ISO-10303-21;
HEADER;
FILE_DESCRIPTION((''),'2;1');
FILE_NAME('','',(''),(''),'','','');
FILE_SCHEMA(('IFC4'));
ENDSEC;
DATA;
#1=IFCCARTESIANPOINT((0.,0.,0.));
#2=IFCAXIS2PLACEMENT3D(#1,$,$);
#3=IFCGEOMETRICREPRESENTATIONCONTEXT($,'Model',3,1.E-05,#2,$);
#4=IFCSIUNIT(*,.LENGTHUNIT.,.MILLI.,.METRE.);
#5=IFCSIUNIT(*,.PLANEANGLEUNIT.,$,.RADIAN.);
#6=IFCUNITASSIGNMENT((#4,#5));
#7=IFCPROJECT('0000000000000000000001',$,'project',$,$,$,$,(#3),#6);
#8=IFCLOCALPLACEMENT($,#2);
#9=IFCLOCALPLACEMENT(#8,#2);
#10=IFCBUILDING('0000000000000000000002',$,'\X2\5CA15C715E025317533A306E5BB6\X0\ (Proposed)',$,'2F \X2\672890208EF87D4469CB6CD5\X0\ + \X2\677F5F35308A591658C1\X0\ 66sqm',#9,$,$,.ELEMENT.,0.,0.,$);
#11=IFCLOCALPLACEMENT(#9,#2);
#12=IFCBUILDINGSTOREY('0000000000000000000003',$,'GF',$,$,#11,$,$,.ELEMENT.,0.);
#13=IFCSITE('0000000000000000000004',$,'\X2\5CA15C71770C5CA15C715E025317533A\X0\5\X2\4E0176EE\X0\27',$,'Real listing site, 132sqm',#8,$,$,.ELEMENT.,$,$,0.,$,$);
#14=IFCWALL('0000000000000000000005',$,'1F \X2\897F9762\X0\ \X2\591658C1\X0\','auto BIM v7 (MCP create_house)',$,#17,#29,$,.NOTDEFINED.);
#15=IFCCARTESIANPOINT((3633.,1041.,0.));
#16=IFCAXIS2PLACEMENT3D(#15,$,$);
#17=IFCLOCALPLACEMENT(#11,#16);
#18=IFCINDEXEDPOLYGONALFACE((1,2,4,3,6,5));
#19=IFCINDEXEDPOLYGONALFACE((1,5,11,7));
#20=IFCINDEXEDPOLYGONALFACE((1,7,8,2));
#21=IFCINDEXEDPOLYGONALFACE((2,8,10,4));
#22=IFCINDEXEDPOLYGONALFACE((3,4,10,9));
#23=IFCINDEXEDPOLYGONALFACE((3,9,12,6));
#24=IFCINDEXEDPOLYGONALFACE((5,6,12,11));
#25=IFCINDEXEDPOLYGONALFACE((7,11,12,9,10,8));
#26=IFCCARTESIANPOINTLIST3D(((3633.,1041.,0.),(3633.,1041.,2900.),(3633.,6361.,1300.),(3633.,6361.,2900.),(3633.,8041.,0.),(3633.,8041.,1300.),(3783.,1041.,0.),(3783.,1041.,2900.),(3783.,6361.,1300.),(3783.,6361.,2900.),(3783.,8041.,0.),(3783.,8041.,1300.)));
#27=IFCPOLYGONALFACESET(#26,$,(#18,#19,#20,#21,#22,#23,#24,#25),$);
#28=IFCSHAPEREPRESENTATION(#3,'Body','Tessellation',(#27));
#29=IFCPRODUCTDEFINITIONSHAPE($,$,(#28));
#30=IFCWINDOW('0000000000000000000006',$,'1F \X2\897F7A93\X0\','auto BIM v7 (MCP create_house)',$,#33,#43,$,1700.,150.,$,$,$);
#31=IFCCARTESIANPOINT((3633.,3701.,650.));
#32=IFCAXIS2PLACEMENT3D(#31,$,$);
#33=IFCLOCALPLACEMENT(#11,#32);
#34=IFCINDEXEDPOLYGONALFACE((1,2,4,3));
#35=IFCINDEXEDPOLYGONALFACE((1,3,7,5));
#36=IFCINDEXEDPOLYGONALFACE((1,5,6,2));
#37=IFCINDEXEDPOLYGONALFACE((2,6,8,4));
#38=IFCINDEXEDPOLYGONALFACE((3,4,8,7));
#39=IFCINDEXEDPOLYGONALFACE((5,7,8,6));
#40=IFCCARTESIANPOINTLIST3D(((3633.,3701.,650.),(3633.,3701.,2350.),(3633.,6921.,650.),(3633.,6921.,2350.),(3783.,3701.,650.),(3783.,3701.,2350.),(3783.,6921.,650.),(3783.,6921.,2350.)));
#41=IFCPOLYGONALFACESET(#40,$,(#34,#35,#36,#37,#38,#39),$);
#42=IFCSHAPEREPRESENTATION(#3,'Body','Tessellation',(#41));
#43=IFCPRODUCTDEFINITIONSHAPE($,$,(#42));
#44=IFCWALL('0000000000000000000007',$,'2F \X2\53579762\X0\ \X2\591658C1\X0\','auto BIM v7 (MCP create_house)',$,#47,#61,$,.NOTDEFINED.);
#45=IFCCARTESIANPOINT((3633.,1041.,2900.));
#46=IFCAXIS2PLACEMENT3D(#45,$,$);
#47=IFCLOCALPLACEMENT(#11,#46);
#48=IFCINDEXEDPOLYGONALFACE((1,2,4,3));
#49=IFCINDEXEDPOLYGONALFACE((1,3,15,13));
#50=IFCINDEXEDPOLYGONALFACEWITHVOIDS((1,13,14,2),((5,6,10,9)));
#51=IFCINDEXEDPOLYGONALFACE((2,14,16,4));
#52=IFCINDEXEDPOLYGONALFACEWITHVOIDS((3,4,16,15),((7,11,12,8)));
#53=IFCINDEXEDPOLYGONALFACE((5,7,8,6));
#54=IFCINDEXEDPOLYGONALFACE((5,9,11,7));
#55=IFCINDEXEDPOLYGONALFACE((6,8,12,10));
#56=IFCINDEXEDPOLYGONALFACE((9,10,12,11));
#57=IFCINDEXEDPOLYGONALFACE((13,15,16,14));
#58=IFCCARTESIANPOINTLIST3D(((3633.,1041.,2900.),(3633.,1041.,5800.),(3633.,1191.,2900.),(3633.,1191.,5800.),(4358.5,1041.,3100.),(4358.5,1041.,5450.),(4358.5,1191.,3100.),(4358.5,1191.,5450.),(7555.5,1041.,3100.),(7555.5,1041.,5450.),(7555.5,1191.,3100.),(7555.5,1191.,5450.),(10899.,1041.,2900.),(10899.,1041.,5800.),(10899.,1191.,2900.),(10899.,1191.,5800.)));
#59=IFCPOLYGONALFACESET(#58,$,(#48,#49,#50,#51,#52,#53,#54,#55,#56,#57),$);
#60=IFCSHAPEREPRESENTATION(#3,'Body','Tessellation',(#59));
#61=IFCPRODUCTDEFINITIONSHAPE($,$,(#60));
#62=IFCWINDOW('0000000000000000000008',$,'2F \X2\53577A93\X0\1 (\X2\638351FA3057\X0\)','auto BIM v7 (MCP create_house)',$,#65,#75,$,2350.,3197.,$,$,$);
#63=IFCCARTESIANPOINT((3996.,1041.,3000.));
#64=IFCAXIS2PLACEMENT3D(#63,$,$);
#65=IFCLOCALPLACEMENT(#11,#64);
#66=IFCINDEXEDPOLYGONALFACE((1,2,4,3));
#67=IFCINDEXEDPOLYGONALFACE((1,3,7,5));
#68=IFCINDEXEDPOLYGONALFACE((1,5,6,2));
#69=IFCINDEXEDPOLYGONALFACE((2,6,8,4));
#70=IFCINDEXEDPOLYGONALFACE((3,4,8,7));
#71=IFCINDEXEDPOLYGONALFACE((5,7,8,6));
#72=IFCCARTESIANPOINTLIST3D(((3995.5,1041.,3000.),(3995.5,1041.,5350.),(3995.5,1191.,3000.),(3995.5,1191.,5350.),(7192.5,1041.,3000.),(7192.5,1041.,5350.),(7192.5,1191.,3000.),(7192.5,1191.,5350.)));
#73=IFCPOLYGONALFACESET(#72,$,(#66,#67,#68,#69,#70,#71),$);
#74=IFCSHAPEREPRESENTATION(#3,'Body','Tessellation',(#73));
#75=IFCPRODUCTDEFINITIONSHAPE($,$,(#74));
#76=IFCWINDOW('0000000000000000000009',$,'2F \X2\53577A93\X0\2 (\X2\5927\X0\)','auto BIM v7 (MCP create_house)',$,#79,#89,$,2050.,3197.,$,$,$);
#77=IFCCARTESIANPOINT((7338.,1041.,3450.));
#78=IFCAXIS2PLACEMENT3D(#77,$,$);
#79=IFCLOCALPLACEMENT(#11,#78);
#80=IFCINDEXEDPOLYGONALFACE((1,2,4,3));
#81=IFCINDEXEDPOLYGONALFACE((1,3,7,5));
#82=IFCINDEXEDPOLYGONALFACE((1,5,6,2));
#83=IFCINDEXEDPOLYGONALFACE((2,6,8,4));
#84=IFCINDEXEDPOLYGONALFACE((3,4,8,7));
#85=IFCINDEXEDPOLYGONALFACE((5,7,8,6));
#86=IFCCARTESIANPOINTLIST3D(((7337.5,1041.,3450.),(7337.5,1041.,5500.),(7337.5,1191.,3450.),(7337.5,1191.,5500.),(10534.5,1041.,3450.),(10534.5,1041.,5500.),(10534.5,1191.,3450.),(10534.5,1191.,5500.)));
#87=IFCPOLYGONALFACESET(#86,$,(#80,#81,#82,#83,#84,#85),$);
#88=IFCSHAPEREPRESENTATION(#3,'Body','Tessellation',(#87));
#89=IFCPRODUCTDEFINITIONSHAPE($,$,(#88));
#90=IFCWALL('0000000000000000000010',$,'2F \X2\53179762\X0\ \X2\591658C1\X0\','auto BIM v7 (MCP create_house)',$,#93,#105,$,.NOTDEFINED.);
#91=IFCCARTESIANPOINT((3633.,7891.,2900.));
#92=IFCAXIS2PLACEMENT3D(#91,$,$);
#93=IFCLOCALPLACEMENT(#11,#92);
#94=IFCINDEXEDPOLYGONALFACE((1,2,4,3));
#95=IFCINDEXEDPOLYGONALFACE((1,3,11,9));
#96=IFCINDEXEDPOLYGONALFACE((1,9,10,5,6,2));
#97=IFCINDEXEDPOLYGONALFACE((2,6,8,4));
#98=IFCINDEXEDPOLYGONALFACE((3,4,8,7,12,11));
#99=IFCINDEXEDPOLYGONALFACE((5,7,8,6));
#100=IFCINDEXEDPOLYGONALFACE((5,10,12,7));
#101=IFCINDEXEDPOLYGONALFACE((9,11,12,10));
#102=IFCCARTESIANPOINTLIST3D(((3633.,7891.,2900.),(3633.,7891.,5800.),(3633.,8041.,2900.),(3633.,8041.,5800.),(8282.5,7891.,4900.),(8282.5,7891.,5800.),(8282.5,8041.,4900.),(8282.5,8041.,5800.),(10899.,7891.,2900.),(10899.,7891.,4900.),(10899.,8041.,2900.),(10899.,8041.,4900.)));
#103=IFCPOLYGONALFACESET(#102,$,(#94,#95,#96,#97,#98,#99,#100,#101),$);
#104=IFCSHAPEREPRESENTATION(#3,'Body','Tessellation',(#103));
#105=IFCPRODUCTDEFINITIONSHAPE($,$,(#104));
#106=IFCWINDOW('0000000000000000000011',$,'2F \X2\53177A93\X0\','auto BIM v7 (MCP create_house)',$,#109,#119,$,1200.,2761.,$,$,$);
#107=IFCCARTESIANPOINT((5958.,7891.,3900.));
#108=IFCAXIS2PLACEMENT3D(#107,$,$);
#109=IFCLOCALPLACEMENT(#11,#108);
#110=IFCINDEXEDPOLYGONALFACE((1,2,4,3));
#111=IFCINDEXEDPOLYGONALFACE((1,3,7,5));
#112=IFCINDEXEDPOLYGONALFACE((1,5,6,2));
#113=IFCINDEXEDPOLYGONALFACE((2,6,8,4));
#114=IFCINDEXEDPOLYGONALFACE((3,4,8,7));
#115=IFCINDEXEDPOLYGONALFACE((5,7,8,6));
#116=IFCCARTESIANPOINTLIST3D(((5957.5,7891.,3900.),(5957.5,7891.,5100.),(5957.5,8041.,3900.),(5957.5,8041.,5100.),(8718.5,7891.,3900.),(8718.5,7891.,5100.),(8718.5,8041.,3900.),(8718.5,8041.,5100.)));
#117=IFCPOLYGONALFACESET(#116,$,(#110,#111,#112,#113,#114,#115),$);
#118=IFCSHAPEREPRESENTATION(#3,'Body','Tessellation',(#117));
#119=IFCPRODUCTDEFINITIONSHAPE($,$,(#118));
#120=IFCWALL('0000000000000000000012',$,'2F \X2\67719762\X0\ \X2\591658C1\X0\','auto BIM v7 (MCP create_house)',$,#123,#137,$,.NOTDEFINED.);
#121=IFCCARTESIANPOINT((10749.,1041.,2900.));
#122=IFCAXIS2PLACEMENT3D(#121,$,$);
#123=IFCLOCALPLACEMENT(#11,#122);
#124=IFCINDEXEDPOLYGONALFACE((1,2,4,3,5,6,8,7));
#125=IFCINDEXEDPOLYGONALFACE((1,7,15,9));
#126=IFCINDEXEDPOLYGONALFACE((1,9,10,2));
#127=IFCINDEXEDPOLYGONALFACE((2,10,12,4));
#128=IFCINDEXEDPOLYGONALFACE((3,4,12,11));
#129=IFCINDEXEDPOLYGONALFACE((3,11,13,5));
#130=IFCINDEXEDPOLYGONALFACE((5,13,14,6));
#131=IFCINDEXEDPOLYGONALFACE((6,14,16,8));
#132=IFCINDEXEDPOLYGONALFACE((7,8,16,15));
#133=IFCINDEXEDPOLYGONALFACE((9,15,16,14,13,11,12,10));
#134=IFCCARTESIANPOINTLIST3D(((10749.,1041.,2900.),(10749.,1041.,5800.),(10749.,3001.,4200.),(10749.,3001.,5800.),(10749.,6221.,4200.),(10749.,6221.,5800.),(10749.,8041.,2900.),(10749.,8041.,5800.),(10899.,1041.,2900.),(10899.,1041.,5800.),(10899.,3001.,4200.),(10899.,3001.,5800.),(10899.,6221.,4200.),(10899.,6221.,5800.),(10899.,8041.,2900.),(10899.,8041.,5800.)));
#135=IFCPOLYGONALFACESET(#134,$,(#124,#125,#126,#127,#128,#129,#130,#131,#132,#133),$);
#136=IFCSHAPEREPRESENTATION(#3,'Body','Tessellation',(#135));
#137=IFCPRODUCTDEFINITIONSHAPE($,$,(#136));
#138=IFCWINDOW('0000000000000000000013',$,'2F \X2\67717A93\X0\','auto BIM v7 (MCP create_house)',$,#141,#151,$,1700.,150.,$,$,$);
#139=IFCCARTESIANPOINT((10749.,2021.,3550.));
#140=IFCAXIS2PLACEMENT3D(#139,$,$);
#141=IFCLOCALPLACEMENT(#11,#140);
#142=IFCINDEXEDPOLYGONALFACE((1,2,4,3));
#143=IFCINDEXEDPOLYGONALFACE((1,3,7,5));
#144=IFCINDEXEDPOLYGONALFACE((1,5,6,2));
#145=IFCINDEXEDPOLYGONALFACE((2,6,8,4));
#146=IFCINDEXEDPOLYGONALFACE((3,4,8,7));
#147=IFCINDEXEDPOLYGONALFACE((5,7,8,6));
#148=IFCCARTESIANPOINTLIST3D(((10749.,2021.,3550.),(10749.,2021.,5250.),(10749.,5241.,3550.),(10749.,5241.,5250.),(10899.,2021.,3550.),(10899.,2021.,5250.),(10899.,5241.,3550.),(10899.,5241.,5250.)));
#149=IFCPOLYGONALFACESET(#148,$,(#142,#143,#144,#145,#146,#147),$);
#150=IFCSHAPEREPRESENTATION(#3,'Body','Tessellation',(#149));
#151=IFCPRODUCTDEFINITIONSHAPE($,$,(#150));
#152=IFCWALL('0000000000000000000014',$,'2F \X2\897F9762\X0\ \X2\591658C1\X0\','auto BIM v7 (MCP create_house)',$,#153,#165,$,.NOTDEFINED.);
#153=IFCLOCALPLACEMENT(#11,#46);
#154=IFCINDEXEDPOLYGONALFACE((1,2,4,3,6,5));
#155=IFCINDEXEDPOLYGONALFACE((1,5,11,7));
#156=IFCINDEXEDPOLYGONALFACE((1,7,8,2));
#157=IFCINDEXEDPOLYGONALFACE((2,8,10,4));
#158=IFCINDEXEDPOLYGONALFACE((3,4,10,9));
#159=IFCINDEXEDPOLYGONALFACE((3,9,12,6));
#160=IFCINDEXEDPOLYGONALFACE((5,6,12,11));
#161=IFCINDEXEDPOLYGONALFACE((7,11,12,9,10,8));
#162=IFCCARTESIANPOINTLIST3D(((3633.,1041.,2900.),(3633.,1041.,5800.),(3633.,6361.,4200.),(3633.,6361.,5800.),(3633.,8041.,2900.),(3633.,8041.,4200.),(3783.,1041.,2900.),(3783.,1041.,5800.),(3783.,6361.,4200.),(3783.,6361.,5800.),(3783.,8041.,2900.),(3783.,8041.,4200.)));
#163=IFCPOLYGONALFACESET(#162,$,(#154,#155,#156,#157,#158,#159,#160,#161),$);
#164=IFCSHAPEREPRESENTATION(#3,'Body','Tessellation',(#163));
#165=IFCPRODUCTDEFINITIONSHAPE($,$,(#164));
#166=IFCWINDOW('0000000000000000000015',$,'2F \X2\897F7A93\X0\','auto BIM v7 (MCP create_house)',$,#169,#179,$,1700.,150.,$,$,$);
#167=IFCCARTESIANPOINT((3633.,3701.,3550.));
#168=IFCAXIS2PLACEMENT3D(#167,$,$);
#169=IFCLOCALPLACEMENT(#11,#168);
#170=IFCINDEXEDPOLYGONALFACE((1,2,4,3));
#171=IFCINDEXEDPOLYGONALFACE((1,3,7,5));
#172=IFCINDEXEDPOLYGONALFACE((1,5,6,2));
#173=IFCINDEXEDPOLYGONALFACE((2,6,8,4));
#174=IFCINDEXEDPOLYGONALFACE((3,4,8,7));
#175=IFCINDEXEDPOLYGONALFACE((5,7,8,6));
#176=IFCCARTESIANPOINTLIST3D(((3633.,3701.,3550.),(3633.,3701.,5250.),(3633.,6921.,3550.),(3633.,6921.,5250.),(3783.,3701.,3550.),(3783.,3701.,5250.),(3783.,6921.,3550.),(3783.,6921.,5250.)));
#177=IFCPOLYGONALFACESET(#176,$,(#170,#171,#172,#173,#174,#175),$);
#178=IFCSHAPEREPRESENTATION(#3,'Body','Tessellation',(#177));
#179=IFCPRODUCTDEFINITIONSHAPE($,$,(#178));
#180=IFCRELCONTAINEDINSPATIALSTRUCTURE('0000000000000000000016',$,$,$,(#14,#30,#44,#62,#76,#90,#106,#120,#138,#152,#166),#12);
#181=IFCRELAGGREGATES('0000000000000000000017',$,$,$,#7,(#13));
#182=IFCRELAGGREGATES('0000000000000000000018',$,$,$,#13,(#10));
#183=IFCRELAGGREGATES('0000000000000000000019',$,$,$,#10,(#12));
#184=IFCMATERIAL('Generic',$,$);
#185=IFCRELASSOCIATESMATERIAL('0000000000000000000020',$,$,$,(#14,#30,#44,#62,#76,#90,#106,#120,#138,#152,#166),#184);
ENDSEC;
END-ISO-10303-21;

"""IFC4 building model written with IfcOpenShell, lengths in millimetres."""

from ifc_helpers import new_model, si_unit, frame, frame_2d, origin, place, context, project, spatial, rectangle, extrude, material, element, fill, save


model = new_model("IFC4")

# Units and contexts
model_context = context("Model", 3, precision=1e-05, world=origin())
ifc_project = project(units=[si_unit("LENGTHUNIT", "METRE", prefix="MILLI"), si_unit("PLANEANGLEUNIT", "RADIAN")], contexts=[model_context])

# Site, building, storey
site_placement = place(None, origin())
site = spatial("IfcSite", under=ifc_project, at=site_placement, Name="岡山県岡山市北区5丁目27", ObjectType="Real listing site, 132sqm", CompositionType="ELEMENT", RefElevation=0.0)
building_placement = place(site_placement, origin())
building = spatial("IfcBuilding", under=site, at=building_placement, Name="岡山市北区の家 (Proposed)", ObjectType="2F 木造軸組構法 + 板張り外壁 66sqm", CompositionType="ELEMENT", ElevationOfRefHeight=0.0, ElevationOfTerrain=0.0)
storey_placement = place(building_placement, origin())
storey = spatial("IfcBuildingStorey", under=building, at=storey_placement, Name="GF", CompositionType="ELEMENT", Elevation=0.0)

# Shared definitions
ifc_material = material(Name="Generic")

# Wall, opening, window
wall_1_placement = place(storey_placement, frame((3633.0, 1041.0, 0.0)))
wall_1 = element("IfcWall", 1, at=wall_1_placement, inside=storey, material=ifc_material, Name="1F 西面 外壁", Description="auto BIM v7 (MCP create_house)", PredefinedType="NOTDEFINED", context=model_context, shape_type="SweptSolid", body=[
    extrude(rectangle(XDim=150.0, YDim=7000.0, at=frame_2d((75.0, 3500.0))), frame((3633.0, 1041.0, 0.0)), (0.0, 0.0, 1.0), 2900.0),
])
opening_1_placement = place(storey_placement, frame((3633.0, 3701.0, 650.0)))
opening_1 = element("IfcOpeningElement", 2, at=opening_1_placement, cuts=wall_1, PredefinedType="NOTDEFINED", context=model_context, shape_type="SweptSolid", body=[
    extrude(rectangle(XDim=150.0, YDim=3220.0, at=frame_2d((75.0, 1610.0))), frame((3633.0, 3701.0, 650.0)), (0.0, 0.0, 1.0), 1700.0),
])
window_1_placement = place(storey_placement, frame((3633.0, 3701.0, 650.0)))
window_1 = element("IfcWindow", 3, at=window_1_placement, inside=storey, material=ifc_material, Name="1F 西窓", Description="auto BIM v7 (MCP create_house)", OverallHeight=1700.0, OverallWidth=150.0, context=model_context, shape_type="SweptSolid", body=[
    extrude(rectangle(XDim=150.0, YDim=3220.0, at=frame_2d((75.0, 1610.0))), frame((3633.0, 3701.0, 650.0)), (0.0, 0.0, 1.0), 1700.0),
])
fill(opening_1, window_1)

# Wall, openings, windows
wall_2_placement = place(storey_placement, frame((3633.0, 1041.0, 2900.0)))
wall_2 = element("IfcWall", 4, at=wall_2_placement, inside=storey, material=ifc_material, Name="2F 南面 外壁", Description="auto BIM v7 (MCP create_house)", PredefinedType="NOTDEFINED", context=model_context, shape_type="SweptSolid", body=[
    extrude(rectangle(XDim=7266.0, YDim=150.0, at=frame_2d((3633.0, 75.0))), frame((3633.0, 1041.0, 2900.0)), (0.0, 0.0, 1.0), 2900.0),
])
opening_2_placement = place(storey_placement, frame((3996.0, 1041.0, 3000.0)))
opening_2 = element("IfcOpeningElement", 5, at=opening_2_placement, cuts=wall_2, PredefinedType="NOTDEFINED", context=model_context, shape_type="SweptSolid", body=[
    extrude(rectangle(XDim=3197.0, YDim=150.0, at=frame_2d((1598.0, 75.0))), frame((3996.0, 1041.0, 3000.0)), (0.0, 0.0, 1.0), 2350.0),
])
opening_3_placement = place(storey_placement, frame((7338.0, 1041.0, 3450.0)))
opening_3 = element("IfcOpeningElement", 6, at=opening_3_placement, cuts=wall_2, PredefinedType="NOTDEFINED", context=model_context, shape_type="SweptSolid", body=[
    extrude(rectangle(XDim=3197.0, YDim=150.0, at=frame_2d((1598.0, 75.0))), frame((7338.0, 1041.0, 3450.0)), (0.0, 0.0, 1.0), 2050.0),
])
window_2_placement = place(storey_placement, frame((3996.0, 1041.0, 3000.0)))
window_2 = element("IfcWindow", 7, at=window_2_placement, inside=storey, material=ifc_material, Name="2F 南窓1 (掃出し)", Description="auto BIM v7 (MCP create_house)", OverallHeight=2350.0, OverallWidth=3197.0, context=model_context, shape_type="SweptSolid", body=[
    extrude(rectangle(XDim=3197.0, YDim=150.0, at=frame_2d((1598.0, 75.0))), frame((3996.0, 1041.0, 3000.0)), (0.0, 0.0, 1.0), 2350.0),
])
fill(opening_2, window_2)
window_3_placement = place(storey_placement, frame((7338.0, 1041.0, 3450.0)))
window_3 = element("IfcWindow", 8, at=window_3_placement, inside=storey, material=ifc_material, Name="2F 南窓2 (大)", Description="auto BIM v7 (MCP create_house)", OverallHeight=2050.0, OverallWidth=3197.0, context=model_context, shape_type="SweptSolid", body=[
    extrude(rectangle(XDim=3197.0, YDim=150.0, at=frame_2d((1598.0, 75.0))), frame((7338.0, 1041.0, 3450.0)), (0.0, 0.0, 1.0), 2050.0),
])
fill(opening_3, window_3)

# Walls, openings, windows
wall_3_placement = place(storey_placement, frame((3633.0, 7891.0, 2900.0)))
wall_3 = element("IfcWall", 9, at=wall_3_placement, inside=storey, material=ifc_material, Name="2F 北面 外壁", Description="auto BIM v7 (MCP create_house)", PredefinedType="NOTDEFINED", context=model_context, shape_type="SweptSolid", body=[
    extrude(rectangle(XDim=7266.0, YDim=150.0, at=frame_2d((3633.0, 75.0))), frame((3633.0, 7891.0, 2900.0)), (0.0, 0.0, 1.0), 2900.0),
])
opening_4_placement = place(storey_placement, frame((5958.0, 7891.0, 3900.0)))
opening_4 = element("IfcOpeningElement", 10, at=opening_4_placement, cuts=wall_3, PredefinedType="NOTDEFINED", context=model_context, shape_type="SweptSolid", body=[
    extrude(rectangle(XDim=2761.0, YDim=150.0, at=frame_2d((1380.0, 75.0))), frame((5958.0, 7891.0, 3900.0)), (0.0, 0.0, 1.0), 1200.0),
])
window_4_placement = place(storey_placement, frame((5958.0, 7891.0, 3900.0)))
window_4 = element("IfcWindow", 11, at=window_4_placement, inside=storey, material=ifc_material, Name="2F 北窓", Description="auto BIM v7 (MCP create_house)", OverallHeight=1200.0, OverallWidth=2761.0, context=model_context, shape_type="SweptSolid", body=[
    extrude(rectangle(XDim=2761.0, YDim=150.0, at=frame_2d((1380.0, 75.0))), frame((5958.0, 7891.0, 3900.0)), (0.0, 0.0, 1.0), 1200.0),
])
fill(opening_4, window_4)
wall_4_placement = place(storey_placement, frame((10749.0, 1041.0, 2900.0)))
wall_4 = element("IfcWall", 12, at=wall_4_placement, inside=storey, material=ifc_material, Name="2F 東面 外壁", Description="auto BIM v7 (MCP create_house)", PredefinedType="NOTDEFINED", context=model_context, shape_type="SweptSolid", body=[
    extrude(rectangle(XDim=150.0, YDim=7000.0, at=frame_2d((75.0, 3500.0))), frame((10749.0, 1041.0, 2900.0)), (0.0, 0.0, 1.0), 2900.0),
])
opening_5_placement = place(storey_placement, frame((10749.0, 2021.0, 3550.0)))
opening_5 = element("IfcOpeningElement", 13, at=opening_5_placement, cuts=wall_4, PredefinedType="NOTDEFINED", context=model_context, shape_type="SweptSolid", body=[
    extrude(rectangle(XDim=150.0, YDim=3220.0, at=frame_2d((75.0, 1610.0))), frame((10749.0, 2021.0, 3550.0)), (0.0, 0.0, 1.0), 1700.0),
])
window_5_placement = place(storey_placement, frame((10749.0, 2021.0, 3550.0)))
window_5 = element("IfcWindow", 14, at=window_5_placement, inside=storey, material=ifc_material, Name="2F 東窓", Description="auto BIM v7 (MCP create_house)", OverallHeight=1700.0, OverallWidth=150.0, context=model_context, shape_type="SweptSolid", body=[
    extrude(rectangle(XDim=150.0, YDim=3220.0, at=frame_2d((75.0, 1610.0))), frame((10749.0, 2021.0, 3550.0)), (0.0, 0.0, 1.0), 1700.0),
])
fill(opening_5, window_5)
wall_5_placement = place(storey_placement, frame((3633.0, 1041.0, 2900.0)))
wall_5 = element("IfcWall", 15, at=wall_5_placement, inside=storey, material=ifc_material, Name="2F 西面 外壁", Description="auto BIM v7 (MCP create_house)", PredefinedType="NOTDEFINED", context=model_context, shape_type="SweptSolid", body=[
    extrude(rectangle(XDim=150.0, YDim=7000.0, at=frame_2d((75.0, 3500.0))), frame((3633.0, 1041.0, 2900.0)), (0.0, 0.0, 1.0), 2900.0),
])
opening_6_placement = place(storey_placement, frame((3633.0, 3701.0, 3550.0)))
opening_6 = element("IfcOpeningElement", 16, at=opening_6_placement, cuts=wall_5, PredefinedType="NOTDEFINED", context=model_context, shape_type="SweptSolid", body=[
    extrude(rectangle(XDim=150.0, YDim=3220.0, at=frame_2d((75.0, 1610.0))), frame((3633.0, 3701.0, 3550.0)), (0.0, 0.0, 1.0), 1700.0),
])
window_6_placement = place(storey_placement, frame((3633.0, 3701.0, 3550.0)))
window_6 = element("IfcWindow", 17, at=window_6_placement, inside=storey, material=ifc_material, Name="2F 西窓", Description="auto BIM v7 (MCP create_house)", OverallHeight=1700.0, OverallWidth=150.0, context=model_context, shape_type="SweptSolid", body=[
    extrude(rectangle(XDim=150.0, YDim=3220.0, at=frame_2d((75.0, 1610.0))), frame((3633.0, 3701.0, 3550.0)), (0.0, 0.0, 1.0), 1700.0),
])
fill(opening_6, window_6)

save(model, "model.ifc")
